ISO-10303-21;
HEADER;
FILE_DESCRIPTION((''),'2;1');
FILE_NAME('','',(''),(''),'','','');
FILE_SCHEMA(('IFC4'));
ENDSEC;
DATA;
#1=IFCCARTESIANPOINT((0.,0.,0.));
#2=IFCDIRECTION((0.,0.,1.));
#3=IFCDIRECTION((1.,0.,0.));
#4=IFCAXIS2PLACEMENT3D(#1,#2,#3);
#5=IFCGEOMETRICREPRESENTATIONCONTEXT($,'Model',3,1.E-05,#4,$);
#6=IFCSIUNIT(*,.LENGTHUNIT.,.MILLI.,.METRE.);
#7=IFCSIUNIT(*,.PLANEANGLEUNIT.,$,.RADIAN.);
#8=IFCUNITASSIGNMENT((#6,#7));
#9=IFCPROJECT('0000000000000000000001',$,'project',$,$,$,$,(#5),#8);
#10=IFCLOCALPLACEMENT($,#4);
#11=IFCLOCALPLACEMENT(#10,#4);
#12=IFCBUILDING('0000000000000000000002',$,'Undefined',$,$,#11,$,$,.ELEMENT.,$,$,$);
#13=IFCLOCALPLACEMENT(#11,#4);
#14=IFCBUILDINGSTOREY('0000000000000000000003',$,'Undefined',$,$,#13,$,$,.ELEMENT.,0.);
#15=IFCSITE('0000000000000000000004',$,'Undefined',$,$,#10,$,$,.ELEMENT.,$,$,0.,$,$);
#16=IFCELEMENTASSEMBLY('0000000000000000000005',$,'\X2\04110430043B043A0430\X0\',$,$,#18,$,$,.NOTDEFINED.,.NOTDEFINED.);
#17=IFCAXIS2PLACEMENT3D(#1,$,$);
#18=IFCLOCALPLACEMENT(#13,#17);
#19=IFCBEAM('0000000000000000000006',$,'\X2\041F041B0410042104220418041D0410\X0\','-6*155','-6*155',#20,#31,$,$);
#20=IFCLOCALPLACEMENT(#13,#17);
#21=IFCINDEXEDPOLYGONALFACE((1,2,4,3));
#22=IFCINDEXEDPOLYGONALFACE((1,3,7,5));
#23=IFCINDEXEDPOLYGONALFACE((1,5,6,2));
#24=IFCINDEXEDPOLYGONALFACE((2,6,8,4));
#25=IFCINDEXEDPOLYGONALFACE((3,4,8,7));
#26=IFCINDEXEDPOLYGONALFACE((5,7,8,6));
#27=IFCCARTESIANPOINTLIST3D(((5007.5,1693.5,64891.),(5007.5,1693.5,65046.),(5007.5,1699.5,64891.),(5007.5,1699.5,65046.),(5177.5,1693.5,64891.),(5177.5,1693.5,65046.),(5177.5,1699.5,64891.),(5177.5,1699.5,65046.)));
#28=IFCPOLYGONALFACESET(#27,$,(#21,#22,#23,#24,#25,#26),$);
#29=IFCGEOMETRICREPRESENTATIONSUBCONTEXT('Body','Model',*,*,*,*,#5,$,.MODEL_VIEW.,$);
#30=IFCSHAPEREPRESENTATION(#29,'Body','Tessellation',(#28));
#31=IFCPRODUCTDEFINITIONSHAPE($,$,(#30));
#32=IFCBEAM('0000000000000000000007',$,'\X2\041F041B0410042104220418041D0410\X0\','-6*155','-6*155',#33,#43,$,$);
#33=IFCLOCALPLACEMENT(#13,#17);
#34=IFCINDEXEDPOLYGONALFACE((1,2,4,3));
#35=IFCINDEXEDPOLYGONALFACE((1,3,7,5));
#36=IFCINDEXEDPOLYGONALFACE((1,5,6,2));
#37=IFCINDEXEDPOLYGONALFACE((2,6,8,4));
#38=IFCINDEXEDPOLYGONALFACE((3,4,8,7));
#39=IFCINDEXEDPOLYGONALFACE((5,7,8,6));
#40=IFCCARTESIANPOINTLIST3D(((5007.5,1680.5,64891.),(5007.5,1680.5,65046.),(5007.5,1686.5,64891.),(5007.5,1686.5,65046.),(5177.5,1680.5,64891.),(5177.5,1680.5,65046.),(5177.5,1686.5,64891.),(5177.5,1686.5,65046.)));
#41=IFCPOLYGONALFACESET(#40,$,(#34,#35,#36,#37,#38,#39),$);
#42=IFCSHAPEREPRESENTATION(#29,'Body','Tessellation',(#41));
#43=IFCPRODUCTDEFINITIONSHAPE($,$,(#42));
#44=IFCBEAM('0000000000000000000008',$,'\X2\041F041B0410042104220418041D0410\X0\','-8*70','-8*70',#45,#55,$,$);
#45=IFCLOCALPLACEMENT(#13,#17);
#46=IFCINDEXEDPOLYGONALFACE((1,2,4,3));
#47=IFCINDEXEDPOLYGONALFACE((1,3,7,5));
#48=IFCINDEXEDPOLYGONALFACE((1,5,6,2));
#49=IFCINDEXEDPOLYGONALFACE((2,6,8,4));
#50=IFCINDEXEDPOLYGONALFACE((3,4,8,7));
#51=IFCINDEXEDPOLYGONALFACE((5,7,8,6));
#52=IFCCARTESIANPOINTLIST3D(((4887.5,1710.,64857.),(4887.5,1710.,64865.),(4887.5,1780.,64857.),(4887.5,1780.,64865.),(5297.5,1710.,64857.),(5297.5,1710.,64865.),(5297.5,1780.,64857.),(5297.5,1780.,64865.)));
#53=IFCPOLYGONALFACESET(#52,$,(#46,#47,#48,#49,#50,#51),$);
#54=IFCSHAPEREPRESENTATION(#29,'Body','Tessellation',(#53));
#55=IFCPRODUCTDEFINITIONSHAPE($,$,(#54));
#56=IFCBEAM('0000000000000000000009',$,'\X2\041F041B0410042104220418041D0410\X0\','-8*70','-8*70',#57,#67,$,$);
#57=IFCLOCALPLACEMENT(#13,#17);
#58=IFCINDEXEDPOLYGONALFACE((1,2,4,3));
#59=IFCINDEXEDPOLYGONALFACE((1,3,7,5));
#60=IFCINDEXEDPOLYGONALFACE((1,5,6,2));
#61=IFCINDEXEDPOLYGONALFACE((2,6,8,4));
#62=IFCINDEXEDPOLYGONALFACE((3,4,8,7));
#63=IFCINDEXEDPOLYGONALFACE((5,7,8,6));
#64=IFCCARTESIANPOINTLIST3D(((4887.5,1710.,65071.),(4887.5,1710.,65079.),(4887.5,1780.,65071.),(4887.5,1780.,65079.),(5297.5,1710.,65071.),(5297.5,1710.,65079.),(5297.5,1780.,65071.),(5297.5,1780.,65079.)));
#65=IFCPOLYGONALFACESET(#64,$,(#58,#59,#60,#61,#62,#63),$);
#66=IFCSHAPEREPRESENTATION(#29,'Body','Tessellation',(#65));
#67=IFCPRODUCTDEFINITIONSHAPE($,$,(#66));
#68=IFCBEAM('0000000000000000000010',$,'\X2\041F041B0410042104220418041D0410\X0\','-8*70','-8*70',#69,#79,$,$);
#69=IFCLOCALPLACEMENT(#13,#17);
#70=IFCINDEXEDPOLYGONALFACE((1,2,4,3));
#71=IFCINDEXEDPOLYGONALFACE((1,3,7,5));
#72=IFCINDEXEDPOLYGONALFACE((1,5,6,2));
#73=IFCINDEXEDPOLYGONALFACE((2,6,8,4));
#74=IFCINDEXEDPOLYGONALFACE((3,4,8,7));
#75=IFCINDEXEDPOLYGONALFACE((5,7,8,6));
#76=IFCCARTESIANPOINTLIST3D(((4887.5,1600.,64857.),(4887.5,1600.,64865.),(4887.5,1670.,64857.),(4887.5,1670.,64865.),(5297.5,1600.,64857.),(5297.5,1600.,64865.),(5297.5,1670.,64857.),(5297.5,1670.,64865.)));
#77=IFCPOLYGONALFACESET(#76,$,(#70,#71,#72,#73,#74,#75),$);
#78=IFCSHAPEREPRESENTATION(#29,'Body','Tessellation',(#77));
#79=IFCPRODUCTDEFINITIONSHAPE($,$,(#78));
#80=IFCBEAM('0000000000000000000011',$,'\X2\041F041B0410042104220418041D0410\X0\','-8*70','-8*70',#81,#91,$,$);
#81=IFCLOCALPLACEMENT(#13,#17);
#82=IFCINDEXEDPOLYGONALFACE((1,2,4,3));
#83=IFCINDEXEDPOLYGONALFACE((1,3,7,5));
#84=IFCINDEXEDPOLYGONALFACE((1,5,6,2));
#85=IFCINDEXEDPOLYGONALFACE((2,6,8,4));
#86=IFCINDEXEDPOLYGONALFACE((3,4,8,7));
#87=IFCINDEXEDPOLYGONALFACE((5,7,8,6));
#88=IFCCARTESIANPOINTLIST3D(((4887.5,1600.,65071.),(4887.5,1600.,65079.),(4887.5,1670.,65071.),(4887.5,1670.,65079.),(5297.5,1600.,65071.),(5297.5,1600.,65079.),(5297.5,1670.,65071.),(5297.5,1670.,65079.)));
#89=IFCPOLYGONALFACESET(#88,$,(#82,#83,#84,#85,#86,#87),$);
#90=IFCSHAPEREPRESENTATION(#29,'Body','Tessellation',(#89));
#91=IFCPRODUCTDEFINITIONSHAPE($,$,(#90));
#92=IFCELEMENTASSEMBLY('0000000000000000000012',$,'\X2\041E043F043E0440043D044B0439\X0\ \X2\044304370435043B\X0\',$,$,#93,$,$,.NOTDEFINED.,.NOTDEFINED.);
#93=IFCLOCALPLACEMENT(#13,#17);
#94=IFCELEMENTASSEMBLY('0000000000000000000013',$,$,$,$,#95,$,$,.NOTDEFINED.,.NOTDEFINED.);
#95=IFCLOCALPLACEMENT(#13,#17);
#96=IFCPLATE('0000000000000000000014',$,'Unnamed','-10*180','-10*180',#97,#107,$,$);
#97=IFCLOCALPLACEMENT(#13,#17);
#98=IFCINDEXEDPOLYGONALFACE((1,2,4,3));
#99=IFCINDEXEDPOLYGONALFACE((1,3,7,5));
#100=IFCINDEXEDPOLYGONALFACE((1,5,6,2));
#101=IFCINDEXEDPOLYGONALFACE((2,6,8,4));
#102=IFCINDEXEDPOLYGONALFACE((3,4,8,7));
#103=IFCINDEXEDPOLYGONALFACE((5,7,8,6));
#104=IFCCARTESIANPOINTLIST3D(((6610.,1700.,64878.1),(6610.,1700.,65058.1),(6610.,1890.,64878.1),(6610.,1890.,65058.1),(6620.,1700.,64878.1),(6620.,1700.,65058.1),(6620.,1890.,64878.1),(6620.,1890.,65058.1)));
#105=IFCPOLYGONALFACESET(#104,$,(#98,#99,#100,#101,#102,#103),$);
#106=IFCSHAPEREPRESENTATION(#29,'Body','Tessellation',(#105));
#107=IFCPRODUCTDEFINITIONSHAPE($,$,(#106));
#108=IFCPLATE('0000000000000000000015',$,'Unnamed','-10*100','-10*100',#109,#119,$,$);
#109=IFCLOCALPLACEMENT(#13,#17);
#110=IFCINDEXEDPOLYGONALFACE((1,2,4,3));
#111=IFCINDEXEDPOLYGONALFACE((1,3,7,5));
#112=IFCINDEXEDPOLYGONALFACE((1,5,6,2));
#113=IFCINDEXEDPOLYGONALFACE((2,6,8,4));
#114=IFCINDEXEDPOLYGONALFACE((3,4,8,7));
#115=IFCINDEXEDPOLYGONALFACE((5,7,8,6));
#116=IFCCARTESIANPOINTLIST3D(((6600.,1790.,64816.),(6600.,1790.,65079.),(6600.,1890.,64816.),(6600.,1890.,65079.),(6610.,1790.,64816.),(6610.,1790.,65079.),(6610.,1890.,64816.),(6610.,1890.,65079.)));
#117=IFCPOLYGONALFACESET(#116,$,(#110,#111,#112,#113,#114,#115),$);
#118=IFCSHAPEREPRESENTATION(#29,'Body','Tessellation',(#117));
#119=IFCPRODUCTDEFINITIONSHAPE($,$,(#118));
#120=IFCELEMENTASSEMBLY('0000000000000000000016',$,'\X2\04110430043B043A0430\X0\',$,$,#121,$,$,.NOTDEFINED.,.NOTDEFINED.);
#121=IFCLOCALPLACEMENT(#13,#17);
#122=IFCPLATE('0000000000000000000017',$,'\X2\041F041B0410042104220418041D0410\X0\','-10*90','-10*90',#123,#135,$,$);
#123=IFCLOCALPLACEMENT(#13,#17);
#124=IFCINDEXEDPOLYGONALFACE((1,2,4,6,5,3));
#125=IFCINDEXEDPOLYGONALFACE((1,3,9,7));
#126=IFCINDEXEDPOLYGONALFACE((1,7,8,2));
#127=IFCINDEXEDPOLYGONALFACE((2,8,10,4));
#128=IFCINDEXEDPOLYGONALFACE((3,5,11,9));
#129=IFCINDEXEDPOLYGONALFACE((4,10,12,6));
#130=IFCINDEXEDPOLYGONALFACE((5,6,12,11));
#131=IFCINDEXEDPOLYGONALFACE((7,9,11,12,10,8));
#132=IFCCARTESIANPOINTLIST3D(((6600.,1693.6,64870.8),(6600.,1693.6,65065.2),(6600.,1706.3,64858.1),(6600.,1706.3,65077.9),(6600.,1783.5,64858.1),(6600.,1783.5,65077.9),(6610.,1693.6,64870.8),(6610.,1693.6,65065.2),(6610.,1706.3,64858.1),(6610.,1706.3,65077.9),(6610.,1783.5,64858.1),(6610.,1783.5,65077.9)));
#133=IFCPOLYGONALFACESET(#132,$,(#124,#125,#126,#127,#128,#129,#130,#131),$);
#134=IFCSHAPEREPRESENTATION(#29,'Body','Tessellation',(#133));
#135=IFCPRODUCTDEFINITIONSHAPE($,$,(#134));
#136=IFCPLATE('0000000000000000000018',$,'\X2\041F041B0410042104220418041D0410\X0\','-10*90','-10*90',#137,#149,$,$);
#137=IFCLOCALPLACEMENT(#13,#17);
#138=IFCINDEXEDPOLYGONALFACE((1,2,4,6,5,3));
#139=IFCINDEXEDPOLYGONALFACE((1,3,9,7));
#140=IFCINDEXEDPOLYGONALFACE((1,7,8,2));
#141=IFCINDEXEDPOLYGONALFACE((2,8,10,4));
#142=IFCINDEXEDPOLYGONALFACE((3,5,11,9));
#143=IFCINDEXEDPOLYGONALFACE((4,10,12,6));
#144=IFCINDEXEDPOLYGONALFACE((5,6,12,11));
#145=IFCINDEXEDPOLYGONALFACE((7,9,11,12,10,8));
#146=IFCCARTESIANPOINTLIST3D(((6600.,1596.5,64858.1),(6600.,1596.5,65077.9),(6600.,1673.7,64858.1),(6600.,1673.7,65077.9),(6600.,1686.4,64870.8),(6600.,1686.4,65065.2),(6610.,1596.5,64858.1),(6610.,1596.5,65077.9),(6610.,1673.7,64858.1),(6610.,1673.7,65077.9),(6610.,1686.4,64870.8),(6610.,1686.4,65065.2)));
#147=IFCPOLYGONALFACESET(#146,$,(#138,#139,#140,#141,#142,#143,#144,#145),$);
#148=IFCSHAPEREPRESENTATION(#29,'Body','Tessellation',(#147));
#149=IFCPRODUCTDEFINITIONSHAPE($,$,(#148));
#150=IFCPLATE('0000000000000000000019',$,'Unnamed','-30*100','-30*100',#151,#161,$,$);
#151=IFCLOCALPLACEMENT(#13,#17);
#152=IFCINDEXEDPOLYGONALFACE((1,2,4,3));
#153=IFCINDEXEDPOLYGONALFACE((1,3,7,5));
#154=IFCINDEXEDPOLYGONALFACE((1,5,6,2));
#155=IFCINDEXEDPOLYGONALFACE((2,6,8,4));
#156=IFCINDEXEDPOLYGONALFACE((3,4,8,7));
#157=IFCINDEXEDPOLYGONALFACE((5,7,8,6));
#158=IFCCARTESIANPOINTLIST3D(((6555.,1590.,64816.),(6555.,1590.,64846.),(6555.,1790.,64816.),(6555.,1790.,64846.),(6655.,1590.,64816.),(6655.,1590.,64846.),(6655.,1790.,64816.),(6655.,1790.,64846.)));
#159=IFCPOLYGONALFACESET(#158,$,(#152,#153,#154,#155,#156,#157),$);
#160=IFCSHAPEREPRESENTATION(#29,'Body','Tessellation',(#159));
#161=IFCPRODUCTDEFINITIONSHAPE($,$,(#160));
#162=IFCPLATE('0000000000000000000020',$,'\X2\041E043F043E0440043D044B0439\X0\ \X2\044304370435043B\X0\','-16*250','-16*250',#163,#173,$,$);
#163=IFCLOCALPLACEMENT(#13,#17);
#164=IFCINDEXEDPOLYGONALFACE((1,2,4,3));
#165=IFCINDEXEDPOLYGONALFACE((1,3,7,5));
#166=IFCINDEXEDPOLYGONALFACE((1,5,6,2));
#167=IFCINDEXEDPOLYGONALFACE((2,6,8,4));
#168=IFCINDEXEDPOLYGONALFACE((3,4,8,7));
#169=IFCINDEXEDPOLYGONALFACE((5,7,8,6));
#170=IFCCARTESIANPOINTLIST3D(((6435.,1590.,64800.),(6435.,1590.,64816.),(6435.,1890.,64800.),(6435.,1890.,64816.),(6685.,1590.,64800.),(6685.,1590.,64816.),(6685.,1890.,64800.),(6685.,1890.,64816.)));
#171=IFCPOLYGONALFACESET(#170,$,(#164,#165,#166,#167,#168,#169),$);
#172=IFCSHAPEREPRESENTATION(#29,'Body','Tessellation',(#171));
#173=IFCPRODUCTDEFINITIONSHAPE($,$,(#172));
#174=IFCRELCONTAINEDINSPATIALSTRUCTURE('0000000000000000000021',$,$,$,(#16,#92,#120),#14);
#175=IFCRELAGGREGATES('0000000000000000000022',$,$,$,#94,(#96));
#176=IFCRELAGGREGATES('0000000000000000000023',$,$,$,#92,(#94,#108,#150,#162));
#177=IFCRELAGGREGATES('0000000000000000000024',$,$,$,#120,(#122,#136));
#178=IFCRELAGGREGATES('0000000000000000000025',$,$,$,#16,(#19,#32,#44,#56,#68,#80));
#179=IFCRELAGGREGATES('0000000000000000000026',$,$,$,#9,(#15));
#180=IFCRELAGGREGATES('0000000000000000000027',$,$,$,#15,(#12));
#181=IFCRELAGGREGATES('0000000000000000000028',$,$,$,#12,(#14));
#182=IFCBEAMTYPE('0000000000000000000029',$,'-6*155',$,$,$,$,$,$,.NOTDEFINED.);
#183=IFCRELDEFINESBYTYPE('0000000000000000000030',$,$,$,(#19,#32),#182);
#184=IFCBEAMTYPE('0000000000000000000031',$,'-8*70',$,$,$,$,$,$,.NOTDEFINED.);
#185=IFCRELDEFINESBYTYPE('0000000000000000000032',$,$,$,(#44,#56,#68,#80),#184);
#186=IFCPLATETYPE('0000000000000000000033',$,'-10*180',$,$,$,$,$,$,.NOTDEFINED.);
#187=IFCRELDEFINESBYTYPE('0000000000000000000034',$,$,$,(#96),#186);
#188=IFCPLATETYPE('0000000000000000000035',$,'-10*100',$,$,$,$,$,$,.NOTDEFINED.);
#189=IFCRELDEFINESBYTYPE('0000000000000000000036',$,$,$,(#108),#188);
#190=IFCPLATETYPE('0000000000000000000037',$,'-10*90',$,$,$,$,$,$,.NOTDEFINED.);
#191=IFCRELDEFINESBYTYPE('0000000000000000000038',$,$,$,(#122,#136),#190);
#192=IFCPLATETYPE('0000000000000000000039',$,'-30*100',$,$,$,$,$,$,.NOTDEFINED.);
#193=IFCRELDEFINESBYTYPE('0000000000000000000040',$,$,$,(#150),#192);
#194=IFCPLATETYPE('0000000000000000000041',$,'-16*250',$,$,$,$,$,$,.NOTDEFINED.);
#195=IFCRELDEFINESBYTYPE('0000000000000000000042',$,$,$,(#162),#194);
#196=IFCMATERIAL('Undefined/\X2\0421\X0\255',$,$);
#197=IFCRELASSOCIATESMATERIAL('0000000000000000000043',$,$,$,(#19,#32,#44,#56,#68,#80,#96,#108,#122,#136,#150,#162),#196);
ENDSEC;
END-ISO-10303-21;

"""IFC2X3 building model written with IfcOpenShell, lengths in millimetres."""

from ifc_helpers import new_model, si_unit, frame, origin_with_axes, origin_2d_with_axis, place, context, subcontext, project, spatial, polyline, rectangle, outline, extrude, material, type_object, element, aggregate, save


model = new_model("IFC2X3")

# Units and contexts
model_context = context("Model", 3, precision=1e-05, world=origin_with_axes())
body_context = subcontext(model_context, "Body", "Model", "MODEL_VIEW")
ifc_project = project(units=[si_unit("LENGTHUNIT", "METRE", prefix="MILLI"), si_unit("PLANEANGLEUNIT", "RADIAN")], contexts=[model_context])

# Site, building, storey
site_placement = place(None, origin_with_axes())
site = spatial("IfcSite", under=ifc_project, at=site_placement, Name="Undefined", CompositionType="ELEMENT", RefElevation=0.0)
building_placement = place(site_placement, origin_with_axes())
building = spatial("IfcBuilding", under=site, at=building_placement, Name="Undefined", CompositionType="ELEMENT")
storey_placement = place(building_placement, origin_with_axes())
storey = spatial("IfcBuildingStorey", under=building, at=storey_placement, Name="Undefined", CompositionType="ELEMENT", Elevation=0.0)

# Element assembly, beams
assembly_1_placement = place(storey_placement, origin_with_axes())
assembly_1 = element("IfcElementAssembly", 1, at=assembly_1_placement, inside=storey, Name="Балка", AssemblyPlace="NOTDEFINED", PredefinedType="NOTDEFINED")
ifc_material_1 = material(Name="Undefined/С255")
beam_type_1 = type_object("IfcBeamType", Name="-6*155", PredefinedType="NOTDEFINED")
beam_1_placement = place(assembly_1_placement, frame((5007.5, 1696.5, 64968.5), z_axis=(0.0, 0.0, 1.0), x_axis=(1.0, 0.0, 0.0)))
beam_1 = element("IfcBeam", 2, at=beam_1_placement, type_object=beam_type_1, material=ifc_material_1, Name="ПЛАСТИНА", Description="-6*155", ObjectType="-6*155", context=body_context, shape_type="SweptSolid", body=[
    extrude(rectangle(XDim=6.0, YDim=155.0, at=origin_2d_with_axis()), frame((170.0, 0.0, 0.0), z_axis=(-1.0, 0.0, 0.0), x_axis=(0.0, -1.0, 0.0)), (0.0, 0.0, 1.0), 170.0),
])
beam_2_placement = place(assembly_1_placement, frame((5007.5, 1683.5, 64968.5), z_axis=(0.0, 0.0, 1.0), x_axis=(1.0, 0.0, 0.0)))
beam_2 = element("IfcBeam", 3, at=beam_2_placement, type_object=beam_type_1, material=ifc_material_1, Name="ПЛАСТИНА", Description="-6*155", ObjectType="-6*155", context=body_context, shape_type="SweptSolid", body=[
    extrude(rectangle(XDim=6.0, YDim=155.0, at=origin_2d_with_axis()), frame((170.0, 0.0, 0.0), z_axis=(-1.0, 0.0, 0.0), x_axis=(0.0, -1.0, 0.0)), (0.0, 0.0, 1.0), 170.0),
])
beam_type_2 = type_object("IfcBeamType", Name="-8*70", PredefinedType="NOTDEFINED")
beam_3_placement = place(assembly_1_placement, frame((5297.5, 1745.0, 64861.0), z_axis=(0.0, -1.0, 0.0), x_axis=(-1.0, 0.0, 0.0)))
beam_3 = element("IfcBeam", 4, at=beam_3_placement, type_object=beam_type_2, material=ifc_material_1, Name="ПЛАСТИНА", Description="-8*70", ObjectType="-8*70", context=body_context, shape_type="SweptSolid", body=[
    extrude(rectangle(XDim=8.0, YDim=70.0, at=origin_2d_with_axis()), frame((410.0, 0.0, 0.0), z_axis=(-1.0, 0.0, 0.0), x_axis=(0.0, -1.0, 0.0)), (0.0, 0.0, 1.0), 410.0),
])
beam_4_placement = place(assembly_1_placement, frame((5297.5, 1745.0, 65075.0), z_axis=(0.0, -1.0, 0.0), x_axis=(-1.0, 0.0, 0.0)))
beam_4 = element("IfcBeam", 5, at=beam_4_placement, type_object=beam_type_2, material=ifc_material_1, Name="ПЛАСТИНА", Description="-8*70", ObjectType="-8*70", context=body_context, shape_type="SweptSolid", body=[
    extrude(rectangle(XDim=8.0, YDim=70.0, at=origin_2d_with_axis()), frame((410.0, 0.0, 0.0), z_axis=(-1.0, 0.0, 0.0), x_axis=(0.0, -1.0, 0.0)), (0.0, 0.0, 1.0), 410.0),
])
beam_5_placement = place(assembly_1_placement, frame((5297.5, 1635.0, 64861.0), z_axis=(0.0, -1.0, 0.0), x_axis=(-1.0, 0.0, 0.0)))
beam_5 = element("IfcBeam", 6, at=beam_5_placement, type_object=beam_type_2, material=ifc_material_1, Name="ПЛАСТИНА", Description="-8*70", ObjectType="-8*70", context=body_context, shape_type="SweptSolid", body=[
    extrude(rectangle(XDim=8.0, YDim=70.0, at=origin_2d_with_axis()), frame((410.0, 0.0, 0.0), z_axis=(-1.0, 0.0, 0.0), x_axis=(0.0, -1.0, 0.0)), (0.0, 0.0, 1.0), 410.0),
])
beam_6_placement = place(assembly_1_placement, frame((5297.5, 1635.0, 65075.0), z_axis=(0.0, -1.0, 0.0), x_axis=(-1.0, 0.0, 0.0)))
beam_6 = element("IfcBeam", 7, at=beam_6_placement, type_object=beam_type_2, material=ifc_material_1, Name="ПЛАСТИНА", Description="-8*70", ObjectType="-8*70", context=body_context, shape_type="SweptSolid", body=[
    extrude(rectangle(XDim=8.0, YDim=70.0, at=origin_2d_with_axis()), frame((410.0, 0.0, 0.0), z_axis=(-1.0, 0.0, 0.0), x_axis=(0.0, -1.0, 0.0)), (0.0, 0.0, 1.0), 410.0),
])

# Element assemblies, plates
assembly_2_placement = place(storey_placement, origin_with_axes())
assembly_2 = element("IfcElementAssembly", 8, at=assembly_2_placement, inside=storey, Name="Опорный узел", AssemblyPlace="NOTDEFINED", PredefinedType="NOTDEFINED")
assembly_3_placement = place(assembly_2_placement, origin_with_axes())
assembly_3 = element("IfcElementAssembly", 9, at=assembly_3_placement, AssemblyPlace="NOTDEFINED", PredefinedType="NOTDEFINED")
plate_type_1 = type_object("IfcPlateType", Name="-10*180", PredefinedType="NOTDEFINED")
plate_1_placement = place(assembly_3_placement, frame((6615.0, 1890.0, 65058.1), z_axis=(1.0, 0.0, 0.0), x_axis=(0.0, -1.0, 0.0)))
plate_1 = element("IfcPlate", 10, at=plate_1_placement, type_object=plate_type_1, material=ifc_material_1, Name="Unnamed", Description="-10*180", ObjectType="-10*180", context=body_context, shape_type="SweptSolid", body=[
    extrude(outline(polyline([(0.0, 0.0), (190.0, 0.0), (190.0, 180.0), (0.0, 180.0), (0.0, 0.0)])), frame((0.0, 0.0, -5.0), z_axis=(0.0, 0.0, 1.0), x_axis=(1.0, 0.0, 0.0)), (0.0, 0.0, 1.0), 10.0),
])
aggregate(assembly_3, [plate_1])
plate_type_2 = type_object("IfcPlateType", Name="-10*100", PredefinedType="NOTDEFINED")
plate_2_placement = place(assembly_2_placement, frame((6605.0, 1790.0, 64816.0), z_axis=(-1.0, 0.0, 0.0), x_axis=(0.0, 0.0, 1.0)))
plate_2 = element("IfcPlate", 11, at=plate_2_placement, type_object=plate_type_2, material=ifc_material_1, Name="Unnamed", Description="-10*100", ObjectType="-10*100", context=body_context, shape_type="SweptSolid", body=[
    extrude(outline(polyline([(0.0, 0.0), (263.0, 0.0), (263.0, 100.0), (0.0, 100.0), (0.0, 0.0)])), frame((0.0, 0.0, -5.0), z_axis=(0.0, 0.0, 1.0), x_axis=(1.0, 0.0, 0.0)), (0.0, 0.0, 1.0), 10.0),
])

# Element assembly, plates
assembly_4_placement = place(storey_placement, origin_with_axes())
assembly_4 = element("IfcElementAssembly", 12, at=assembly_4_placement, inside=storey, Name="Балка", AssemblyPlace="NOTDEFINED", PredefinedType="NOTDEFINED")
plate_type_3 = type_object("IfcPlateType", Name="-10*90", PredefinedType="NOTDEFINED")
plate_3_placement = place(assembly_4_placement, frame((6605.0, 1693.6, 65077.9), z_axis=(-1.0, 0.0, 0.0), x_axis=(0.0, 1.0, 0.0)))
plate_3 = element("IfcPlate", 13, at=plate_3_placement, type_object=plate_type_3, material=ifc_material_1, Name="ПЛАСТИНА", Description="-10*90", ObjectType="-10*90", context=body_context, shape_type="SweptSolid", body=[
    extrude(outline(polyline([(0.0, 12.7), (12.7, 0.0), (89.9, 0.0), (89.9, 219.8), (12.7, 219.8), (0.0, 207.1), (0.0, 12.7)])), frame((0.0, 0.0, -5.0), z_axis=(0.0, 0.0, 1.0), x_axis=(1.0, 0.0, 0.0)), (0.0, 0.0, 1.0), 10.0),
])
plate_4_placement = place(assembly_4_placement, frame((6605.0, 1596.5, 65077.9), z_axis=(-1.0, 0.0, 0.0), x_axis=(0.0, 1.0, 0.0)))
plate_4 = element("IfcPlate", 14, at=plate_4_placement, type_object=plate_type_3, material=ifc_material_1, Name="ПЛАСТИНА", Description="-10*90", ObjectType="-10*90", context=body_context, shape_type="SweptSolid", body=[
    extrude(outline(polyline([(0.0, 0.0), (77.2, 0.0), (89.9, 12.7), (89.9, 207.1), (77.2, 219.8), (0.0, 219.8), (0.0, 0.0)])), frame((0.0, 0.0, -5.0), z_axis=(0.0, 0.0, 1.0), x_axis=(1.0, 0.0, 0.0)), (0.0, 0.0, 1.0), 10.0),
])

# Plates
plate_type_4 = type_object("IfcPlateType", Name="-30*100", PredefinedType="NOTDEFINED")
plate_5_placement = place(assembly_2_placement, frame((6655.0, 1590.0, 64831.0), z_axis=(0.0, 0.0, 1.0), x_axis=(0.0, 1.0, 0.0)))
plate_5 = element("IfcPlate", 15, at=plate_5_placement, type_object=plate_type_4, material=ifc_material_1, Name="Unnamed", Description="-30*100", ObjectType="-30*100", context=body_context, shape_type="SweptSolid", body=[
    extrude(outline(polyline([(0.0, 0.0), (200.0, 0.0), (200.0, 100.0), (0.0, 100.0), (0.0, 0.0)])), frame((0.0, 0.0, -15.0), z_axis=(0.0, 0.0, 1.0), x_axis=(1.0, 0.0, 0.0)), (0.0, 0.0, 1.0), 30.0),
])
plate_type_5 = type_object("IfcPlateType", Name="-16*250", PredefinedType="NOTDEFINED")
plate_6_placement = place(assembly_2_placement, frame((6685.0, 1590.0, 64808.0), z_axis=(0.0, 0.0, 1.0), x_axis=(0.0, 1.0, 0.0)))
plate_6 = element("IfcPlate", 16, at=plate_6_placement, type_object=plate_type_5, material=ifc_material_1, Name="Опорный узел", Description="-16*250", ObjectType="-16*250", context=body_context, shape_type="SweptSolid", body=[
    extrude(outline(polyline([(0.0, 0.0), (300.0, 0.0), (300.0, 250.0), (0.0, 250.0), (0.0, 0.0)])), frame((0.0, 0.0, -8.0), z_axis=(0.0, 0.0, 1.0), x_axis=(1.0, 0.0, 0.0)), (0.0, 0.0, 1.0), 16.0),
])
aggregate(assembly_2, [assembly_3, plate_2, plate_5, plate_6])

aggregate(assembly_4, [plate_3, plate_4])

aggregate(assembly_1, [beam_1, beam_2, beam_3, beam_4, beam_5, beam_6])

save(model, "model.ifc")
